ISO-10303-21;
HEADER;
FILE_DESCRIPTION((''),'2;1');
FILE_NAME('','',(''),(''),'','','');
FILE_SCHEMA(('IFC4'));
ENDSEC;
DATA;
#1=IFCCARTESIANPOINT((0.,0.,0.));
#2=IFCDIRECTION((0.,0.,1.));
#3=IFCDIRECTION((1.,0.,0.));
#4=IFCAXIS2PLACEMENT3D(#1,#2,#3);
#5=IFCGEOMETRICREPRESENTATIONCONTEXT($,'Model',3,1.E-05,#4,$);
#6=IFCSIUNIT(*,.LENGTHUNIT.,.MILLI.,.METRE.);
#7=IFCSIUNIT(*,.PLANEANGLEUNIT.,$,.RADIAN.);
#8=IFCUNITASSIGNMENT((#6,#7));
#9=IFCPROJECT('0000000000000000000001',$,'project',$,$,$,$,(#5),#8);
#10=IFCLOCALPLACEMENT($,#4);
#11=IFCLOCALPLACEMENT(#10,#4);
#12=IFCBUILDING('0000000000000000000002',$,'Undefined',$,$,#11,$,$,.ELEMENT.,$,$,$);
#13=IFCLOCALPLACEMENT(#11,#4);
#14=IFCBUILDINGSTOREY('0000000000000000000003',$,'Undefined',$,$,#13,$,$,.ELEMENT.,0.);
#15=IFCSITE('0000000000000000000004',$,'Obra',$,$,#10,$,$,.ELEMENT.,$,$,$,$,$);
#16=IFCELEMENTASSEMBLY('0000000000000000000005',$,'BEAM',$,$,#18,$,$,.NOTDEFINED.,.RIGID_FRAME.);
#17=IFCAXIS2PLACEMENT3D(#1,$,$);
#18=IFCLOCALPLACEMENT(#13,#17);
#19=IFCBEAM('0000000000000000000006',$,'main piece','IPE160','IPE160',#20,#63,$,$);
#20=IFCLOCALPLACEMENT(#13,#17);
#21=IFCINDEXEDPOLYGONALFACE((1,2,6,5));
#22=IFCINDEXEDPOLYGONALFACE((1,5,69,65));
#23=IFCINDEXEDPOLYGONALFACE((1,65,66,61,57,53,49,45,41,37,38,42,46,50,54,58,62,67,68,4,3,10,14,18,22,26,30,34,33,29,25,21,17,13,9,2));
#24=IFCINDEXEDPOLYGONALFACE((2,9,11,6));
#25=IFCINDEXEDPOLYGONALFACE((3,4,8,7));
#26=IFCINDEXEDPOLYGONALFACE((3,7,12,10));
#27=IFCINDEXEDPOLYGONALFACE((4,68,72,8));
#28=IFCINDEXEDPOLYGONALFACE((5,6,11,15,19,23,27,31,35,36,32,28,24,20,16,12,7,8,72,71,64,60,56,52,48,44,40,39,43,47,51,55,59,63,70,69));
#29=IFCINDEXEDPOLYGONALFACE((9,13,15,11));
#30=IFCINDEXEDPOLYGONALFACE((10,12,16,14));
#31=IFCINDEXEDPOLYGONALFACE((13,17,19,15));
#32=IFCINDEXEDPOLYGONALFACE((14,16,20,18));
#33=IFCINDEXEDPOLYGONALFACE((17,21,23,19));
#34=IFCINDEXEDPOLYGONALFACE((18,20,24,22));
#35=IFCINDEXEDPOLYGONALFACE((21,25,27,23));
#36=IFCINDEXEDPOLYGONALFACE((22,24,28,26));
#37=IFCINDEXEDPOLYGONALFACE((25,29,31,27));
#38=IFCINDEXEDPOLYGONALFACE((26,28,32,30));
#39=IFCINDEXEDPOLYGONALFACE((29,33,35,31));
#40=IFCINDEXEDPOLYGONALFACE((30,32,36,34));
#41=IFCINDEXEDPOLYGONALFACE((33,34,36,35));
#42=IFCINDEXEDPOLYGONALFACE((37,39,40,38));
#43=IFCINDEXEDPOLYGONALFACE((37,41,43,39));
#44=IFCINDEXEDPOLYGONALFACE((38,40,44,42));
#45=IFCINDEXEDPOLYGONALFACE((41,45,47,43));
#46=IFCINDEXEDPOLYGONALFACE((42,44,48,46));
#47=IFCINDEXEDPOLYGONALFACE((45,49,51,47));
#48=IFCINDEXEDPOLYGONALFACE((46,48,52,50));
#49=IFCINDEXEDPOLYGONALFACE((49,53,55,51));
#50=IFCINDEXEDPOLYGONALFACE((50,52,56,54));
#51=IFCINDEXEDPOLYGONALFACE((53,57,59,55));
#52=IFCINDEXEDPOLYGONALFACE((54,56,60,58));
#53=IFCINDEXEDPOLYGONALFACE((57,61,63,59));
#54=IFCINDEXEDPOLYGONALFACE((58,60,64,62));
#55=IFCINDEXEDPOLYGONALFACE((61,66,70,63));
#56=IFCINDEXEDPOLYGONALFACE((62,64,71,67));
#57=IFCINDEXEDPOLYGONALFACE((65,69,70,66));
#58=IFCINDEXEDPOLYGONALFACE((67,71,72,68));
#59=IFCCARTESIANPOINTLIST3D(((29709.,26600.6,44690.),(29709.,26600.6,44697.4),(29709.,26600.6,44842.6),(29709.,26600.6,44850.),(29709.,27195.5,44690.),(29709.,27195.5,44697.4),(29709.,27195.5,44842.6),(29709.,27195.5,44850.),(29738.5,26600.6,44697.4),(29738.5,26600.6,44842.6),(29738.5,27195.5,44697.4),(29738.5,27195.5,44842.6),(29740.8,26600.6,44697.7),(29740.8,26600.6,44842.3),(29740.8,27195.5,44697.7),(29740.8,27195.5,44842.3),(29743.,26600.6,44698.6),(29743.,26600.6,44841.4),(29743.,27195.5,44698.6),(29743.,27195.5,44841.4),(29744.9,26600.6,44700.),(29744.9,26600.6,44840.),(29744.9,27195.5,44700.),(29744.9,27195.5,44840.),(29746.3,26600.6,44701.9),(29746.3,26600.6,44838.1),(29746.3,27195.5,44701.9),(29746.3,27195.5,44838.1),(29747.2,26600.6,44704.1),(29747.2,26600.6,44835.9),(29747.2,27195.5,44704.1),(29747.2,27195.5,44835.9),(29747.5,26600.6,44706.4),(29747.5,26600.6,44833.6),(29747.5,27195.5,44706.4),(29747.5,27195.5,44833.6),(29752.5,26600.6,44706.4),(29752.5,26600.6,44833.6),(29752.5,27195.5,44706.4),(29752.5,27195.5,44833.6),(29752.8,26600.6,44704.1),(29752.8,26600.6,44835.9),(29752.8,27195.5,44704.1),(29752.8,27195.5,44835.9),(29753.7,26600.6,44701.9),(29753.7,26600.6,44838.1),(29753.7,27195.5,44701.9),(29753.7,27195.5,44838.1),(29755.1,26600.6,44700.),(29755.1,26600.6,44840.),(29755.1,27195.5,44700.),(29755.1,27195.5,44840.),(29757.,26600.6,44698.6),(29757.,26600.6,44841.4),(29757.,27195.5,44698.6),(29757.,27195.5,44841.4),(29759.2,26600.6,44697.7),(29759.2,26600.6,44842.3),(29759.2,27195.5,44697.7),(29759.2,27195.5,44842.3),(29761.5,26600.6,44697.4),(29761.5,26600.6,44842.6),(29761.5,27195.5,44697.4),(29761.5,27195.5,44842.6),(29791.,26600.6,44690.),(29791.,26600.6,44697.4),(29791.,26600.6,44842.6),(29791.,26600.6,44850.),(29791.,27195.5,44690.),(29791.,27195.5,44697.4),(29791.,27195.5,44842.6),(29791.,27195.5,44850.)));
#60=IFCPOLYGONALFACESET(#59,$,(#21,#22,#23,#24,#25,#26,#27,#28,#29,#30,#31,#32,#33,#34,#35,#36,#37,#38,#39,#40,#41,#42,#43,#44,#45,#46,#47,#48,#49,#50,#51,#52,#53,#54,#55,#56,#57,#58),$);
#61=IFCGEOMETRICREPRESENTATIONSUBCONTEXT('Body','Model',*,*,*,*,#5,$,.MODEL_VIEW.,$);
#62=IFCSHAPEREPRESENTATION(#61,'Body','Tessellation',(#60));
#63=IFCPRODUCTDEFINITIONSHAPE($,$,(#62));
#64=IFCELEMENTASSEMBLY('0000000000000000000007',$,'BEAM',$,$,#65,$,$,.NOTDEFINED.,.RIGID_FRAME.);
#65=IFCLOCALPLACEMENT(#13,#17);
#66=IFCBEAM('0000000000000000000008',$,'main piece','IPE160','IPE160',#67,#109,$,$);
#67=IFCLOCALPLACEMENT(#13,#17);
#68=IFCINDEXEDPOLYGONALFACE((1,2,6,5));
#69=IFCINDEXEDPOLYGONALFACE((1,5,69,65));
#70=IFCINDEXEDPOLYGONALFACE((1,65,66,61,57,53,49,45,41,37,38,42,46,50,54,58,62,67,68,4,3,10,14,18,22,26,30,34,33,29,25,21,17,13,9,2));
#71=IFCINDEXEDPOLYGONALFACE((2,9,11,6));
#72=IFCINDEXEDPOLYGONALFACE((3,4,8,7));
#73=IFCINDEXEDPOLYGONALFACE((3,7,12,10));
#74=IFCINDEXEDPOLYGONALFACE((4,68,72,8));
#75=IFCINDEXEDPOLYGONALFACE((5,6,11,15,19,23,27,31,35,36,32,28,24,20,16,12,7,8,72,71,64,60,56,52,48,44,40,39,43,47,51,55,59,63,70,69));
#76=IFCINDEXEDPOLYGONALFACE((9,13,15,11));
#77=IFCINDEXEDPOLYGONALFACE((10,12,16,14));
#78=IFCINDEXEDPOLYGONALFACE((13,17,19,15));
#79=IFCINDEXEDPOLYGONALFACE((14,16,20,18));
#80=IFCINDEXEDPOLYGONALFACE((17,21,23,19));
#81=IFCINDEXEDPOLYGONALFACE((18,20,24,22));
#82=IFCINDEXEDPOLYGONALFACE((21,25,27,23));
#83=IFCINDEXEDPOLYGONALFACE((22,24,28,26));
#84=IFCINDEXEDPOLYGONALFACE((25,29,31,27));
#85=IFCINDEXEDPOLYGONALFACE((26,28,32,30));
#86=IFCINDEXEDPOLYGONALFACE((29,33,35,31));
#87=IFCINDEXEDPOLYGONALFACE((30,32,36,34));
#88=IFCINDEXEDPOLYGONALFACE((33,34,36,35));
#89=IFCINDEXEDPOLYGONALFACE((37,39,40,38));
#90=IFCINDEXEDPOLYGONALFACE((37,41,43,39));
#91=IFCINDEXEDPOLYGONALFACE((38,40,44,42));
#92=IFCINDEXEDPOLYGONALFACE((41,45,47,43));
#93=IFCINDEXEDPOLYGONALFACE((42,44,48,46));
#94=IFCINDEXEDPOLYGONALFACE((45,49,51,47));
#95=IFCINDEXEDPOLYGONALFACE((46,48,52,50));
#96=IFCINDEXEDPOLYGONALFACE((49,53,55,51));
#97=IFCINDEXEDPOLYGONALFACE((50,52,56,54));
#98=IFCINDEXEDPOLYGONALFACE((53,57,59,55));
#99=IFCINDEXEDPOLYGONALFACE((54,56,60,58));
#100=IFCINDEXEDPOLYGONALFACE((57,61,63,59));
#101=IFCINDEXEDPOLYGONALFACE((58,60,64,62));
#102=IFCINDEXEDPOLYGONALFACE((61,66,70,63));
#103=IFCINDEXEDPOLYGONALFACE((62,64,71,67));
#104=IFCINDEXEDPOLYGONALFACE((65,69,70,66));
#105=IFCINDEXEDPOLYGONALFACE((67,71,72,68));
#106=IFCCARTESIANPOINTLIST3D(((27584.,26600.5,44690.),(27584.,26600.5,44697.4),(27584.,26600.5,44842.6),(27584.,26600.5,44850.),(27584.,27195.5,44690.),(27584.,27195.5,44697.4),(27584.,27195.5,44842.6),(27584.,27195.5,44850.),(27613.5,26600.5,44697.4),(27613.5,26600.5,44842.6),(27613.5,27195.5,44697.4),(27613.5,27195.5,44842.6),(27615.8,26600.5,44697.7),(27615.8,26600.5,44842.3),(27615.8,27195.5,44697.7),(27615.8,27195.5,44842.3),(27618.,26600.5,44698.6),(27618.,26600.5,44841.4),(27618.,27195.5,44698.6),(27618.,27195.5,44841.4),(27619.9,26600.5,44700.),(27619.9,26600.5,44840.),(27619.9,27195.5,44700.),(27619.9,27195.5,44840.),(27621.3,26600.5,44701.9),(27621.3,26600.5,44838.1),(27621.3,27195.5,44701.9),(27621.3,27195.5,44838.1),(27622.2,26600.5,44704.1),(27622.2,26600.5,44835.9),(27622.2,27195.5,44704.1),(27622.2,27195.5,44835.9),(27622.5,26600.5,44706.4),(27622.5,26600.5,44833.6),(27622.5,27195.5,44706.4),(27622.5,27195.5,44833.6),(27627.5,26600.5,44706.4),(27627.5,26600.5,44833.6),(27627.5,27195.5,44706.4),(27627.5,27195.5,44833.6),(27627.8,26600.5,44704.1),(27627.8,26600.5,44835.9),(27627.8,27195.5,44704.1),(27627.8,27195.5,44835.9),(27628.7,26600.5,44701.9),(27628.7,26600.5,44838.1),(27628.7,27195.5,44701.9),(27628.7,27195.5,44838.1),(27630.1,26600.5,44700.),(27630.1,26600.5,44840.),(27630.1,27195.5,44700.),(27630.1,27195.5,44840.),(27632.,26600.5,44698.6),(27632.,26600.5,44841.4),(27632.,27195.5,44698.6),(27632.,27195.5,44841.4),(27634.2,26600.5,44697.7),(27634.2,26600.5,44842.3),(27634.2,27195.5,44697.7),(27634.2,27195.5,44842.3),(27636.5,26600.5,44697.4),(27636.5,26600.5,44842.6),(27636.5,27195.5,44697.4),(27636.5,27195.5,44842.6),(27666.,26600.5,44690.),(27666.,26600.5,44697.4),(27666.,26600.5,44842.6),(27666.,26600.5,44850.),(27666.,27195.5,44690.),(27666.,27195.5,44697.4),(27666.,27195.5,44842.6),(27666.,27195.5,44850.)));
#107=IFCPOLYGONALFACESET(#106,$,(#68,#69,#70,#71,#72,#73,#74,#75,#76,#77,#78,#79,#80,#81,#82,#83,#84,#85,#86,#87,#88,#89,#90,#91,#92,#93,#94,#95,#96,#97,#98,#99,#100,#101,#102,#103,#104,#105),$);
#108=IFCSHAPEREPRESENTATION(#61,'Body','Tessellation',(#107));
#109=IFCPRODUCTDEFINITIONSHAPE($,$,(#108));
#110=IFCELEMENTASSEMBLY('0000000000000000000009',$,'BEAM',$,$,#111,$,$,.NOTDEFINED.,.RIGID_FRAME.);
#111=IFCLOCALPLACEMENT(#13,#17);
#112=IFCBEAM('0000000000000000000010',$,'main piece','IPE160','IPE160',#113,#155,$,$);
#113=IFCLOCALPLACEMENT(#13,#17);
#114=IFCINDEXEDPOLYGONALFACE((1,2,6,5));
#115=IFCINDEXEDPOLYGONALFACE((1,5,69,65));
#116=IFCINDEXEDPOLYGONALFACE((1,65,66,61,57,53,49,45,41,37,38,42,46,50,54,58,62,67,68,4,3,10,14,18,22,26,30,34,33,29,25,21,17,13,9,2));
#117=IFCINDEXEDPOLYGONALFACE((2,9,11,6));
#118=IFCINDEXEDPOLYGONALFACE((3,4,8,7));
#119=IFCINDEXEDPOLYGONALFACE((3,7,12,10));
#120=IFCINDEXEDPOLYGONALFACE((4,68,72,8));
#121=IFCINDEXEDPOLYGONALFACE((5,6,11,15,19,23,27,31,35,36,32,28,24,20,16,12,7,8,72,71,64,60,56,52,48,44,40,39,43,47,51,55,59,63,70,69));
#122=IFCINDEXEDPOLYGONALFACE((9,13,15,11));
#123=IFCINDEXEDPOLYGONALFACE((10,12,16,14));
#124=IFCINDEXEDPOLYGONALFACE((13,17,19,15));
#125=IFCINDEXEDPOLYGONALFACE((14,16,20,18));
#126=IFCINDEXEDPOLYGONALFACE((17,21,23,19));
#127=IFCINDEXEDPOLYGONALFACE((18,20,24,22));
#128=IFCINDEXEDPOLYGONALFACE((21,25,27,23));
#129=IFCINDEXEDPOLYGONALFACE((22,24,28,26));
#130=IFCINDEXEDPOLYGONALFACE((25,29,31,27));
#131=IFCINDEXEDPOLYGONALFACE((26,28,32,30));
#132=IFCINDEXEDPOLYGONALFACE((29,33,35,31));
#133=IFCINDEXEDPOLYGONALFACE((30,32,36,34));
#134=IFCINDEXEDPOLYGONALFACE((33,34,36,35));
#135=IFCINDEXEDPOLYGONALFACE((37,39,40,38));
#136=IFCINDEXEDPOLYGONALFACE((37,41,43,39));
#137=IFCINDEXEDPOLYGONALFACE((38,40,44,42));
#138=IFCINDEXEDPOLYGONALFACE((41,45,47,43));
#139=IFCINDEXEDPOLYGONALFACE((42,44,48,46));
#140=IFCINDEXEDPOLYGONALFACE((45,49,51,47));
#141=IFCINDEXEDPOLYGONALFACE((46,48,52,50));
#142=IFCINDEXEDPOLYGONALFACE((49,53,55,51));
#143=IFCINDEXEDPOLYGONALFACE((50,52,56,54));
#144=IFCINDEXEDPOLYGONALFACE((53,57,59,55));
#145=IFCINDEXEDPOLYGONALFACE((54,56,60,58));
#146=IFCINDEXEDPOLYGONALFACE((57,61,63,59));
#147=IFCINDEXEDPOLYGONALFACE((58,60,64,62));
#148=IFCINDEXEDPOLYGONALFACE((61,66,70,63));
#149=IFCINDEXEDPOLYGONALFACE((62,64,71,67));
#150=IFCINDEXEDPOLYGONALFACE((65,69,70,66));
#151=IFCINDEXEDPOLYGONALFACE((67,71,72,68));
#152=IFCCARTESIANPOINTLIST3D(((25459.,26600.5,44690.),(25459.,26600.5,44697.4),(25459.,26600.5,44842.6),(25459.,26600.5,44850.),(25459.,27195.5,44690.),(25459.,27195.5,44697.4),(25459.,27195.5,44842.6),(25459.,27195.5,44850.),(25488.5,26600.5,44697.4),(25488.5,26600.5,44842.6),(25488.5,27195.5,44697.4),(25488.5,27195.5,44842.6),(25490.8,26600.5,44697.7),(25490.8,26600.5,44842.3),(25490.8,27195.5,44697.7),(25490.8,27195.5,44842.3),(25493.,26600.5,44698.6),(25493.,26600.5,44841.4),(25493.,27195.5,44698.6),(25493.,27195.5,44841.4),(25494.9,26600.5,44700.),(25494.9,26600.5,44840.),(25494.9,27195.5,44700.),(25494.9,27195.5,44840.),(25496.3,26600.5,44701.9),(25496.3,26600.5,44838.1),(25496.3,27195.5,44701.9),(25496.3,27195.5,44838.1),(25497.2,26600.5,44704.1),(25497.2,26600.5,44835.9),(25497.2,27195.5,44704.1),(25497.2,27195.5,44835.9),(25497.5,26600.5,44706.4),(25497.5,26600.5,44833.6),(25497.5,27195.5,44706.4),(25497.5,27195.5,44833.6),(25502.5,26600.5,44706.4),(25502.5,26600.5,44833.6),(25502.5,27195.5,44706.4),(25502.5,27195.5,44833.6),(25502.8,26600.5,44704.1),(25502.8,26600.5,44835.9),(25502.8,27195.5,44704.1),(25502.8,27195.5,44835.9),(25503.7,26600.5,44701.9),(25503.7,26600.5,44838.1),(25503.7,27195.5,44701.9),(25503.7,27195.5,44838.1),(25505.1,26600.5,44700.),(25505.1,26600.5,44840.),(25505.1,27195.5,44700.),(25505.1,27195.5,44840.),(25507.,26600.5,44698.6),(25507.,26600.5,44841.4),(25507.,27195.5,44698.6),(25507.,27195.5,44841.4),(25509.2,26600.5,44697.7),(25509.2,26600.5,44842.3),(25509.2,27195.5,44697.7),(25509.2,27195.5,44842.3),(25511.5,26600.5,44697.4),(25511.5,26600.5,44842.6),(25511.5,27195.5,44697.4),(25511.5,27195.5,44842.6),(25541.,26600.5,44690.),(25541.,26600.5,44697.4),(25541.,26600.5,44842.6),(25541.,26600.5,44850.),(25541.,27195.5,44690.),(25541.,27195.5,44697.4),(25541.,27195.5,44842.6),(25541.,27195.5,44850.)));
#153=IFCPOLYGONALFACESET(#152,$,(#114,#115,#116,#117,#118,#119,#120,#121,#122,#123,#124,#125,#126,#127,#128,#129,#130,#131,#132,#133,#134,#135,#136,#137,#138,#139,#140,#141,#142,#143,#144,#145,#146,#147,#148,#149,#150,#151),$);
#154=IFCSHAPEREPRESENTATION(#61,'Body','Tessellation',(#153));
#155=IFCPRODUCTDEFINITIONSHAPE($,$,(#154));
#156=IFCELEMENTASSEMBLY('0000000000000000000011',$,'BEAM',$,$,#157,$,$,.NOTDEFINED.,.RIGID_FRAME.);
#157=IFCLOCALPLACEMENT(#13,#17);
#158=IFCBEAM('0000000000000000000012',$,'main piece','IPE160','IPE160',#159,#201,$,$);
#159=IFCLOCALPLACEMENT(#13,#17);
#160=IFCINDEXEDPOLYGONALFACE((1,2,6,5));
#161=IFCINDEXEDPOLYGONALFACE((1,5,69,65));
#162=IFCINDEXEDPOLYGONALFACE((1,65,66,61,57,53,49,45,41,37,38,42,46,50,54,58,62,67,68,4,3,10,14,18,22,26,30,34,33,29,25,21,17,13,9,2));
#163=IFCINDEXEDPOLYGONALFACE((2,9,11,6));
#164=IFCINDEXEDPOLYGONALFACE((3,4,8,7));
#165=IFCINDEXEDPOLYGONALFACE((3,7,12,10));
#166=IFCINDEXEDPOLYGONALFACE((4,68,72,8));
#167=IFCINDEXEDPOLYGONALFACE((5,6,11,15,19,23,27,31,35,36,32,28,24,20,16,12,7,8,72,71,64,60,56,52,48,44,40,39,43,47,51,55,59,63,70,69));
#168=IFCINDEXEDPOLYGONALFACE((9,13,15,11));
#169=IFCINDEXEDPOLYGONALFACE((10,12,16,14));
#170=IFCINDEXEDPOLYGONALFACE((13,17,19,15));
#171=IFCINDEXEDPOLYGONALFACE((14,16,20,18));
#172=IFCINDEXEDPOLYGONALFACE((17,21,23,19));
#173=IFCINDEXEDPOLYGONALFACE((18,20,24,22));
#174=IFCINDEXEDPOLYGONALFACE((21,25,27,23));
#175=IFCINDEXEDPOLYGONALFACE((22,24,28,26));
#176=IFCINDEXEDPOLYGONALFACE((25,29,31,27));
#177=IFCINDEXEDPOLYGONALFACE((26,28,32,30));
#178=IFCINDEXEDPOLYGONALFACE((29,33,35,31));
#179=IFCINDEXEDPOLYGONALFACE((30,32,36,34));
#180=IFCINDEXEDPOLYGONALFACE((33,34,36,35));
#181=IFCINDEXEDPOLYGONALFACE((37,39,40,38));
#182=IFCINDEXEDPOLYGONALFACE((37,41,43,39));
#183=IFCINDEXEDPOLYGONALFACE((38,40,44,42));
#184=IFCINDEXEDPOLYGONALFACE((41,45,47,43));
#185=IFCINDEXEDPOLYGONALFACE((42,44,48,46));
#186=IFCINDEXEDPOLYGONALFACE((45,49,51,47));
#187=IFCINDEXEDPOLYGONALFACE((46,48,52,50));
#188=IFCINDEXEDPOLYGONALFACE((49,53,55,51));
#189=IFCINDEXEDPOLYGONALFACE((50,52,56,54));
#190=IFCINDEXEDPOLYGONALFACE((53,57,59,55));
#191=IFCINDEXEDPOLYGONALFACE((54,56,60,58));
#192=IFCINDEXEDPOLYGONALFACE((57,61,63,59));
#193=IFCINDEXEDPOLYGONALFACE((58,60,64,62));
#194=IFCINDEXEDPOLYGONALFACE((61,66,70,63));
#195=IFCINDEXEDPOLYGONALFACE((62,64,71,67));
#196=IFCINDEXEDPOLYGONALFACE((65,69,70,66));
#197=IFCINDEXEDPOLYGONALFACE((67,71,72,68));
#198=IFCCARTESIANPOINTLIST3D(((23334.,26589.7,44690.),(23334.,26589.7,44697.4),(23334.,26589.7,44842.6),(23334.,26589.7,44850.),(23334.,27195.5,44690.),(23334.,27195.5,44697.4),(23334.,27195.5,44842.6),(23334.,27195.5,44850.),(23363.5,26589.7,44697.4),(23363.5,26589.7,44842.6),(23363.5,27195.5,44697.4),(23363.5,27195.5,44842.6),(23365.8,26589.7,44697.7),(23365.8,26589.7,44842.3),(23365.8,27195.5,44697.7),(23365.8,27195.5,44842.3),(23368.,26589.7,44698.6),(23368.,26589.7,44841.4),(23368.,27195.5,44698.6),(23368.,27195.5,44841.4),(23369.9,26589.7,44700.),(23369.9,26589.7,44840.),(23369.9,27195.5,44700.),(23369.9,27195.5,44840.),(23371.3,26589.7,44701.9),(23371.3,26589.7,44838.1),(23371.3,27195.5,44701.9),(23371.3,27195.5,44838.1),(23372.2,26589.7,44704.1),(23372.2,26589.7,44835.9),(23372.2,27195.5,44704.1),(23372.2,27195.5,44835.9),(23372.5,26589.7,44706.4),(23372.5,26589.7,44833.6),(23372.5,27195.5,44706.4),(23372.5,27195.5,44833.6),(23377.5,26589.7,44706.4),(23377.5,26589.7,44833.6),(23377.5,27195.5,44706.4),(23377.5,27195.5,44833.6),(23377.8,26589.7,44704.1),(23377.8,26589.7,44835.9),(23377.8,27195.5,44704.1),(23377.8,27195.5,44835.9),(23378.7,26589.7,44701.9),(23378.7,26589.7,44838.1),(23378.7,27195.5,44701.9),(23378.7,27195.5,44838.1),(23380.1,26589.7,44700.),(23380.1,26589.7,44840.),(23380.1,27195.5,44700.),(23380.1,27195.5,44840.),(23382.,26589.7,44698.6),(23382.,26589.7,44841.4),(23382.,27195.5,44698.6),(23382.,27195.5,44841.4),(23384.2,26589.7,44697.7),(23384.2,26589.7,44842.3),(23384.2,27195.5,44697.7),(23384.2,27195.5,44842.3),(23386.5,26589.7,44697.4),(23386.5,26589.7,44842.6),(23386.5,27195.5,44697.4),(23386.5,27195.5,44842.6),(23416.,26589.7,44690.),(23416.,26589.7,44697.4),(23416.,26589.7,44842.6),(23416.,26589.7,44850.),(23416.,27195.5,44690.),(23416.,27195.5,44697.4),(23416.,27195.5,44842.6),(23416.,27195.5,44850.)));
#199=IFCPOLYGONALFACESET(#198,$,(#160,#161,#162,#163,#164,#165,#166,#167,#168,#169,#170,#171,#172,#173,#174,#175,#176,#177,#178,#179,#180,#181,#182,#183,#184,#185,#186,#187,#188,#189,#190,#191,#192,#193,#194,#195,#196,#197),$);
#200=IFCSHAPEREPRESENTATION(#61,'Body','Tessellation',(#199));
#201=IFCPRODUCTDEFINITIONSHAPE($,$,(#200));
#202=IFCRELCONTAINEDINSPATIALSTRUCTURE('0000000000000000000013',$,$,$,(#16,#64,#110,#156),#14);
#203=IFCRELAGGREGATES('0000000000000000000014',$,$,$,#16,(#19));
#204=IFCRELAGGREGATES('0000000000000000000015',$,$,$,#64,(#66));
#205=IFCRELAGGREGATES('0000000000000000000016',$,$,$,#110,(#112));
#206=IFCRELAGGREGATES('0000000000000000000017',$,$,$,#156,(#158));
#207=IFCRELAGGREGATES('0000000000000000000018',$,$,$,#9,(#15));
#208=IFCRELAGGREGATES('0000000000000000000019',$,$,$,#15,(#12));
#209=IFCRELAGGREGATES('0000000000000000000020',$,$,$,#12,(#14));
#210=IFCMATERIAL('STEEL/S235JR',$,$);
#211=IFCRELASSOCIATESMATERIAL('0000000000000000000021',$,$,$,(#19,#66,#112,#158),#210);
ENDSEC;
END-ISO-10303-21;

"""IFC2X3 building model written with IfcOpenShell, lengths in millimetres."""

from ifc_helpers import new_model, si_unit, frame, origin_with_axes, origin_2d_with_axis, place, context, subcontext, project, spatial, i_section, extrude, material, element, aggregate, save


model = new_model("IFC2X3")

# Units and contexts
model_context = context("Model", 3, precision=1e-05, world=origin_with_axes())
body_context = subcontext(model_context, "Body", "Model", "MODEL_VIEW")
ifc_project = project(units=[si_unit("LENGTHUNIT", "METRE", prefix="MILLI"), si_unit("PLANEANGLEUNIT", "RADIAN")], contexts=[model_context])

# Site, building, storey
site_placement = place(None, origin_with_axes())
site = spatial("IfcSite", under=ifc_project, at=site_placement, Name="Obra", CompositionType="ELEMENT")
building_placement = place(site_placement, origin_with_axes())
building = spatial("IfcBuilding", under=site, at=building_placement, Name="Undefined", CompositionType="ELEMENT")
storey_placement = place(building_placement, origin_with_axes())
storey = spatial("IfcBuildingStorey", under=building, at=storey_placement, Name="Undefined", CompositionType="ELEMENT", Elevation=0.0)

# Shared definitions
ifc_material_1 = material(Name="STEEL/S235JR")

# Element assemblies, beams
assembly_1_placement = place(storey_placement, origin_with_axes())
assembly_1 = element("IfcElementAssembly", 1, at=assembly_1_placement, inside=storey, Name="BEAM", AssemblyPlace="NOTDEFINED", PredefinedType="RIGID_FRAME")
beam_1_placement = place(assembly_1_placement, frame((29750.0, 26600.6, 44770.0), z_axis=(0.0, 0.0, 1.0), x_axis=(0.0, 1.0, 0.0)))
beam_1 = element("IfcBeam", 2, at=beam_1_placement, material=ifc_material_1, Name="main piece", Description="IPE160", ObjectType="IPE160", context=body_context, shape_type="SweptSolid", body=[
    extrude(i_section(OverallWidth=82.0, OverallDepth=160.0, WebThickness=5.0, FlangeThickness=7.4, FilletRadius=9.0, at=origin_2d_with_axis()), frame((594.9, 0.0, 0.0), z_axis=(-1.0, 0.0, 0.0), x_axis=(0.0, -1.0, 0.0)), (0.0, 0.0, 1.0), 594.9),
])
aggregate(assembly_1, [beam_1])
assembly_2_placement = place(storey_placement, origin_with_axes())
assembly_2 = element("IfcElementAssembly", 3, at=assembly_2_placement, inside=storey, Name="BEAM", AssemblyPlace="NOTDEFINED", PredefinedType="RIGID_FRAME")
beam_2_placement = place(assembly_2_placement, frame((27625.0, 26600.5, 44770.0), z_axis=(0.0, 0.0, 1.0), x_axis=(0.0, 1.0, 0.0)))
beam_2 = element("IfcBeam", 4, at=beam_2_placement, material=ifc_material_1, Name="main piece", Description="IPE160", ObjectType="IPE160", context=body_context, shape_type="SweptSolid", body=[
    extrude(i_section(OverallWidth=82.0, OverallDepth=160.0, WebThickness=5.0, FlangeThickness=7.4, FilletRadius=9.0, at=origin_2d_with_axis()), frame((595.0, 0.0, 0.0), z_axis=(-1.0, 0.0, 0.0), x_axis=(0.0, -1.0, 0.0)), (0.0, 0.0, 1.0), 595.0),
])
aggregate(assembly_2, [beam_2])
assembly_3_placement = place(storey_placement, origin_with_axes())
assembly_3 = element("IfcElementAssembly", 5, at=assembly_3_placement, inside=storey, Name="BEAM", AssemblyPlace="NOTDEFINED", PredefinedType="RIGID_FRAME")
beam_3_placement = place(assembly_3_placement, frame((25500.0, 26600.5, 44770.0), z_axis=(0.0, 0.0, 1.0), x_axis=(0.0, 1.0, 0.0)))
beam_3 = element("IfcBeam", 6, at=beam_3_placement, material=ifc_material_1, Name="main piece", Description="IPE160", ObjectType="IPE160", context=body_context, shape_type="SweptSolid", body=[
    extrude(i_section(OverallWidth=82.0, OverallDepth=160.0, WebThickness=5.0, FlangeThickness=7.4, FilletRadius=9.0, at=origin_2d_with_axis()), frame((595.0, 0.0, 0.0), z_axis=(-1.0, 0.0, 0.0), x_axis=(0.0, -1.0, 0.0)), (0.0, 0.0, 1.0), 595.0),
])
aggregate(assembly_3, [beam_3])
assembly_4_placement = place(storey_placement, origin_with_axes())
assembly_4 = element("IfcElementAssembly", 7, at=assembly_4_placement, inside=storey, Name="BEAM", AssemblyPlace="NOTDEFINED", PredefinedType="RIGID_FRAME")
beam_4_placement = place(assembly_4_placement, frame((23375.0, 26589.6, 44770.0), z_axis=(0.0, 0.0, 1.0), x_axis=(0.0, 1.0, 0.0)))
beam_4 = element("IfcBeam", 8, at=beam_4_placement, material=ifc_material_1, Name="main piece", Description="IPE160", ObjectType="IPE160", context=body_context, shape_type="SweptSolid", body=[
    extrude(i_section(OverallWidth=82.0, OverallDepth=160.0, WebThickness=5.0, FlangeThickness=7.4, FilletRadius=9.0, at=origin_2d_with_axis()), frame((605.9, 0.0, 0.0), z_axis=(-1.0, 0.0, 0.0), x_axis=(0.0, -1.0, 0.0)), (0.0, 0.0, 1.0), 605.9),
])
aggregate(assembly_4, [beam_4])

save(model, "model.ifc")
